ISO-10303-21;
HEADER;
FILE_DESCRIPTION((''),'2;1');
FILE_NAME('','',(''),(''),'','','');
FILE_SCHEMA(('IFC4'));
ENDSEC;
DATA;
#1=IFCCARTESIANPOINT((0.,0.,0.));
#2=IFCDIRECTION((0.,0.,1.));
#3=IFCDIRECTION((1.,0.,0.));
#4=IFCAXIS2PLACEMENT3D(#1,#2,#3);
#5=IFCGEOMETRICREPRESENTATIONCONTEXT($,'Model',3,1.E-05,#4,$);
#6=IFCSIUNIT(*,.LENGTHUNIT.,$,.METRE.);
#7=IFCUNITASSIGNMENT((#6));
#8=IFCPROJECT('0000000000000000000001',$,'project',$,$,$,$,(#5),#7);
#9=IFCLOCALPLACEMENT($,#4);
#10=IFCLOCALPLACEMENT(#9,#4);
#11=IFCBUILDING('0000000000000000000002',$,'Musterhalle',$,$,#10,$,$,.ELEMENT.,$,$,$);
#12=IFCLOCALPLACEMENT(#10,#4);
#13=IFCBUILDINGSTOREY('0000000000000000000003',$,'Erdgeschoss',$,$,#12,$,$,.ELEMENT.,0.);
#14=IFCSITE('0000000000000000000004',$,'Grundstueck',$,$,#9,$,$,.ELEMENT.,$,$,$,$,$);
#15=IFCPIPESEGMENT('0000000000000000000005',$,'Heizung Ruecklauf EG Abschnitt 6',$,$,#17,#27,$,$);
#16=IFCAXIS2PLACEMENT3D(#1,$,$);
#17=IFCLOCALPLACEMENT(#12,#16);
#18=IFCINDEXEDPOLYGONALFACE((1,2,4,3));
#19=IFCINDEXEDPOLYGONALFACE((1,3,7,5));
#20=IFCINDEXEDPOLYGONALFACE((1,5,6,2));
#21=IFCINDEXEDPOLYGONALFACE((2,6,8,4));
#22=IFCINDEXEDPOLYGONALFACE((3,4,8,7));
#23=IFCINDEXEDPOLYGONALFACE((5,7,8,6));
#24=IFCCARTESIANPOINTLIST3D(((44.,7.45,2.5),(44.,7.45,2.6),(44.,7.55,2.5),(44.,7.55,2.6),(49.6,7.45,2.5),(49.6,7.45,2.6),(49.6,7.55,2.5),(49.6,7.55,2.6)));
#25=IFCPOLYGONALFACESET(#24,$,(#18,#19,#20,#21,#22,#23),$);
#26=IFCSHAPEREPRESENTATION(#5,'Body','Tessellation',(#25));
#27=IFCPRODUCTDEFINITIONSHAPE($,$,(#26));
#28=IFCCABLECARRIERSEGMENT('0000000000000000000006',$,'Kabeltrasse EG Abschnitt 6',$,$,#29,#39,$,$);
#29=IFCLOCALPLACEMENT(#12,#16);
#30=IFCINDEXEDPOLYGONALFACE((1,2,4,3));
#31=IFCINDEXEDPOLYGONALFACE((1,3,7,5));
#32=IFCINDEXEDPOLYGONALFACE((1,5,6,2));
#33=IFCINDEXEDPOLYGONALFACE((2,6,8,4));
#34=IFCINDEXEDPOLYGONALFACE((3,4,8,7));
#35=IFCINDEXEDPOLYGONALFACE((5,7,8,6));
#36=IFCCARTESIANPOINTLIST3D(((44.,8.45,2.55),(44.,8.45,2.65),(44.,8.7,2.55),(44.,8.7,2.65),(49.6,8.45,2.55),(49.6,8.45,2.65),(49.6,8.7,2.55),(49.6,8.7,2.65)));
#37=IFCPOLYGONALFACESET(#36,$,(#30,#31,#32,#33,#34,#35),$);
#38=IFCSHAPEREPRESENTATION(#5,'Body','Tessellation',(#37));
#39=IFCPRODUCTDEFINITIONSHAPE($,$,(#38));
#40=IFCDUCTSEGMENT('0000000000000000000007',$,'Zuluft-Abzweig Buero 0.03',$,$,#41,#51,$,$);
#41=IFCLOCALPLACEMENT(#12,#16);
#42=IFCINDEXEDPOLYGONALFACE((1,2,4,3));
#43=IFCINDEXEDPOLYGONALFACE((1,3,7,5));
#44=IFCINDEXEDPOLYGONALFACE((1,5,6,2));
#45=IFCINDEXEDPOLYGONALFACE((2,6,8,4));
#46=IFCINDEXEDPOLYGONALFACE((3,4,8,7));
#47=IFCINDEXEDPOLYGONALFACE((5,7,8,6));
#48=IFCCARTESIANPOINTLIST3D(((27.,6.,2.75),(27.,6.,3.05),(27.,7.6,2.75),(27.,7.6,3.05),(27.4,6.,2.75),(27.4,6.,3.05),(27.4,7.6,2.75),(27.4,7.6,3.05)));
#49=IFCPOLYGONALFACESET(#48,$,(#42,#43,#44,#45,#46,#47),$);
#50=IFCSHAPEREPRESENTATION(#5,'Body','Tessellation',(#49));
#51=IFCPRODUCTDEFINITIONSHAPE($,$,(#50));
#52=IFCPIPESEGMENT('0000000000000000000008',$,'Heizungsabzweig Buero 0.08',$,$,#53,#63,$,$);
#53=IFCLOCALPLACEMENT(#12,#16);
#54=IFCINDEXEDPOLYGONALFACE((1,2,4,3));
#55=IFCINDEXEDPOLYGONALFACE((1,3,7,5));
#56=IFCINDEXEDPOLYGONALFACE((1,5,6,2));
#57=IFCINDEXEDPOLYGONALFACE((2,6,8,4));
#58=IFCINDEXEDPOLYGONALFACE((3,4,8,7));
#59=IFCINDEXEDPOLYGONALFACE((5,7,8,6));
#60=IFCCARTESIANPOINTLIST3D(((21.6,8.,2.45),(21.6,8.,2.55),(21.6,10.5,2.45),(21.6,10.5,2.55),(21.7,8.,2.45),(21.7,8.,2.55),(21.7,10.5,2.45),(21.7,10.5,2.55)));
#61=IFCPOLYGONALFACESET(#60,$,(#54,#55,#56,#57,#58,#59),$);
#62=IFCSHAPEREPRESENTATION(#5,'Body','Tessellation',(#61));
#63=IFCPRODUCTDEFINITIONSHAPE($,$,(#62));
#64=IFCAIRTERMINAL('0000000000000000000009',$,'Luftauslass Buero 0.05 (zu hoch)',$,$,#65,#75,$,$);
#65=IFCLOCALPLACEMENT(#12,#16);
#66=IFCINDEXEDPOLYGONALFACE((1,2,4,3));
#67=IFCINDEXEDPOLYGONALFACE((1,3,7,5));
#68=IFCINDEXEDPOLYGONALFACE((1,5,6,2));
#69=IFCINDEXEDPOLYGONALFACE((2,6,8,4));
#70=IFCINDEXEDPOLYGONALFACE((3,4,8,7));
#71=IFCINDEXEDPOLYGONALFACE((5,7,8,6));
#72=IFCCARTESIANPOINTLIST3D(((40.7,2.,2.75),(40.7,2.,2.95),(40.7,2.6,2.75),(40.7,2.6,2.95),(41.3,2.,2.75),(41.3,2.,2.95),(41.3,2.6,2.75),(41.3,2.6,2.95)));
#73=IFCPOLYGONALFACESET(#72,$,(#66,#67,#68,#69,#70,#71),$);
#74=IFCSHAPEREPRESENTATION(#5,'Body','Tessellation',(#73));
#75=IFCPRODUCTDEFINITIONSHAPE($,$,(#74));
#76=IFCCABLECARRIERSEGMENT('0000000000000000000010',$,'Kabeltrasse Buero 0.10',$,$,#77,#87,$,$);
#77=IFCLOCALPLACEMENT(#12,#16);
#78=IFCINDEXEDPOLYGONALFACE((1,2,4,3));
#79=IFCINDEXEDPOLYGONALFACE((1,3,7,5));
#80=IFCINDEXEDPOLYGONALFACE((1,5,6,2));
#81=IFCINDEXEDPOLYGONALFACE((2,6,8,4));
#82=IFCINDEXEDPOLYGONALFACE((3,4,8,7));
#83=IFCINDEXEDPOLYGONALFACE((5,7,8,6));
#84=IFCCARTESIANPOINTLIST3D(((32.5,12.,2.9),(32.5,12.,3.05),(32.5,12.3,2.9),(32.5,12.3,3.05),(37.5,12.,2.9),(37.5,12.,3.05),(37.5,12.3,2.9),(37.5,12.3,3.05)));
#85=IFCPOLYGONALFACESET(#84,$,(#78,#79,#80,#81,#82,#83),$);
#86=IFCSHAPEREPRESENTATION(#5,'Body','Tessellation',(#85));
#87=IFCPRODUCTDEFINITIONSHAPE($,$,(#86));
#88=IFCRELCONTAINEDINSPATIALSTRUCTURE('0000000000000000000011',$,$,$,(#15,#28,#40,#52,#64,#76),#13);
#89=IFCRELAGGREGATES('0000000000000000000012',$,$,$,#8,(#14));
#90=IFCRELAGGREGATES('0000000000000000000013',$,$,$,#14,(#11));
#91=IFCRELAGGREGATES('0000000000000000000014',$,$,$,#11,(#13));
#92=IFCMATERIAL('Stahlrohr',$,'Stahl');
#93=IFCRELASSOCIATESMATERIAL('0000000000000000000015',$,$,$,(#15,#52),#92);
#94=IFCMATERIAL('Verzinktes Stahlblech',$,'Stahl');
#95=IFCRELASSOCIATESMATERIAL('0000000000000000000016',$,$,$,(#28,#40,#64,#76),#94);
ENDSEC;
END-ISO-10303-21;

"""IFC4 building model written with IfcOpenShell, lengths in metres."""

from ifc_helpers import new_model, si_unit, frame, origin_with_axes, origin_2d, place, context, project, spatial, rectangle, extrude, material, element, save


model = new_model("IFC4")

# Units and contexts
model_context = context("Model", 3, precision=1e-05, world=origin_with_axes())
ifc_project = project(units=[si_unit("LENGTHUNIT", "METRE")], contexts=[model_context])

# Site, building, storey
site_placement = place(None, origin_with_axes())
site = spatial("IfcSite", under=ifc_project, at=site_placement, Name="Grundstueck", CompositionType="ELEMENT")
building_placement = place(site_placement, origin_with_axes())
building = spatial("IfcBuilding", under=site, at=building_placement, Name="Musterhalle", CompositionType="ELEMENT")
storey_placement = place(building_placement, origin_with_axes())
storey = spatial("IfcBuildingStorey", under=building, at=storey_placement, Name="Erdgeschoss", CompositionType="ELEMENT", Elevation=0.0)

# Shared definitions
placement = place(storey_placement, origin_with_axes())

# Shared definitions
ifc_material_1 = material(Name="Stahlrohr", Category="Stahl")

# Shared definitions
ifc_material_2 = material(Name="Verzinktes Stahlblech", Category="Stahl")

# Pipe segment
element("IfcPipeSegment", 1, at=placement, inside=storey, material=ifc_material_1, Name="Heizung Ruecklauf EG Abschnitt 6", context=model_context, shape_type="SweptSolid", body=[
    extrude(rectangle(XDim=5.6, YDim=0.1, at=origin_2d()), frame((46.8, 7.5, 2.5), z_axis=(0.0, 0.0, 1.0), x_axis=(1.0, 0.0, 0.0)), (0.0, 0.0, 1.0), 0.1),
])

# Cable carrier segment
element("IfcCableCarrierSegment", 2, at=placement, inside=storey, material=ifc_material_2, Name="Kabeltrasse EG Abschnitt 6", context=model_context, shape_type="SweptSolid", body=[
    extrude(rectangle(XDim=5.6, YDim=0.25, at=origin_2d()), frame((46.8, 8.575, 2.55), z_axis=(0.0, 0.0, 1.0), x_axis=(1.0, 0.0, 0.0)), (0.0, 0.0, 1.0), 0.1),
])

# Duct segment
element("IfcDuctSegment", 3, at=placement, inside=storey, material=ifc_material_2, Name="Zuluft-Abzweig Buero 0.03", context=model_context, shape_type="SweptSolid", body=[
    extrude(rectangle(XDim=0.4, YDim=1.6, at=origin_2d()), frame((27.2, 6.8, 2.75), z_axis=(0.0, 0.0, 1.0), x_axis=(1.0, 0.0, 0.0)), (0.0, 0.0, 1.0), 0.3),
])

# Pipe segment
element("IfcPipeSegment", 4, at=placement, inside=storey, material=ifc_material_1, Name="Heizungsabzweig Buero 0.08", context=model_context, shape_type="SweptSolid", body=[
    extrude(rectangle(XDim=0.1, YDim=2.5, at=origin_2d()), frame((21.65, 9.25, 2.45), z_axis=(0.0, 0.0, 1.0), x_axis=(1.0, 0.0, 0.0)), (0.0, 0.0, 1.0), 0.1),
])

# Air terminal
element("IfcAirTerminal", 5, at=placement, inside=storey, material=ifc_material_2, Name="Luftauslass Buero 0.05 (zu hoch)", context=model_context, shape_type="SweptSolid", body=[
    extrude(rectangle(XDim=0.6, YDim=0.6, at=origin_2d()), frame((41.0, 2.3, 2.75), z_axis=(0.0, 0.0, 1.0), x_axis=(1.0, 0.0, 0.0)), (0.0, 0.0, 1.0), 0.2),
])

# Cable carrier segment
element("IfcCableCarrierSegment", 6, at=placement, inside=storey, material=ifc_material_2, Name="Kabeltrasse Buero 0.10", context=model_context, shape_type="SweptSolid", body=[
    extrude(rectangle(XDim=5.0, YDim=0.3, at=origin_2d()), frame((35.0, 12.15, 2.9), z_axis=(0.0, 0.0, 1.0), x_axis=(1.0, 0.0, 0.0)), (0.0, 0.0, 1.0), 0.15),
])

save(model, "model.ifc")
